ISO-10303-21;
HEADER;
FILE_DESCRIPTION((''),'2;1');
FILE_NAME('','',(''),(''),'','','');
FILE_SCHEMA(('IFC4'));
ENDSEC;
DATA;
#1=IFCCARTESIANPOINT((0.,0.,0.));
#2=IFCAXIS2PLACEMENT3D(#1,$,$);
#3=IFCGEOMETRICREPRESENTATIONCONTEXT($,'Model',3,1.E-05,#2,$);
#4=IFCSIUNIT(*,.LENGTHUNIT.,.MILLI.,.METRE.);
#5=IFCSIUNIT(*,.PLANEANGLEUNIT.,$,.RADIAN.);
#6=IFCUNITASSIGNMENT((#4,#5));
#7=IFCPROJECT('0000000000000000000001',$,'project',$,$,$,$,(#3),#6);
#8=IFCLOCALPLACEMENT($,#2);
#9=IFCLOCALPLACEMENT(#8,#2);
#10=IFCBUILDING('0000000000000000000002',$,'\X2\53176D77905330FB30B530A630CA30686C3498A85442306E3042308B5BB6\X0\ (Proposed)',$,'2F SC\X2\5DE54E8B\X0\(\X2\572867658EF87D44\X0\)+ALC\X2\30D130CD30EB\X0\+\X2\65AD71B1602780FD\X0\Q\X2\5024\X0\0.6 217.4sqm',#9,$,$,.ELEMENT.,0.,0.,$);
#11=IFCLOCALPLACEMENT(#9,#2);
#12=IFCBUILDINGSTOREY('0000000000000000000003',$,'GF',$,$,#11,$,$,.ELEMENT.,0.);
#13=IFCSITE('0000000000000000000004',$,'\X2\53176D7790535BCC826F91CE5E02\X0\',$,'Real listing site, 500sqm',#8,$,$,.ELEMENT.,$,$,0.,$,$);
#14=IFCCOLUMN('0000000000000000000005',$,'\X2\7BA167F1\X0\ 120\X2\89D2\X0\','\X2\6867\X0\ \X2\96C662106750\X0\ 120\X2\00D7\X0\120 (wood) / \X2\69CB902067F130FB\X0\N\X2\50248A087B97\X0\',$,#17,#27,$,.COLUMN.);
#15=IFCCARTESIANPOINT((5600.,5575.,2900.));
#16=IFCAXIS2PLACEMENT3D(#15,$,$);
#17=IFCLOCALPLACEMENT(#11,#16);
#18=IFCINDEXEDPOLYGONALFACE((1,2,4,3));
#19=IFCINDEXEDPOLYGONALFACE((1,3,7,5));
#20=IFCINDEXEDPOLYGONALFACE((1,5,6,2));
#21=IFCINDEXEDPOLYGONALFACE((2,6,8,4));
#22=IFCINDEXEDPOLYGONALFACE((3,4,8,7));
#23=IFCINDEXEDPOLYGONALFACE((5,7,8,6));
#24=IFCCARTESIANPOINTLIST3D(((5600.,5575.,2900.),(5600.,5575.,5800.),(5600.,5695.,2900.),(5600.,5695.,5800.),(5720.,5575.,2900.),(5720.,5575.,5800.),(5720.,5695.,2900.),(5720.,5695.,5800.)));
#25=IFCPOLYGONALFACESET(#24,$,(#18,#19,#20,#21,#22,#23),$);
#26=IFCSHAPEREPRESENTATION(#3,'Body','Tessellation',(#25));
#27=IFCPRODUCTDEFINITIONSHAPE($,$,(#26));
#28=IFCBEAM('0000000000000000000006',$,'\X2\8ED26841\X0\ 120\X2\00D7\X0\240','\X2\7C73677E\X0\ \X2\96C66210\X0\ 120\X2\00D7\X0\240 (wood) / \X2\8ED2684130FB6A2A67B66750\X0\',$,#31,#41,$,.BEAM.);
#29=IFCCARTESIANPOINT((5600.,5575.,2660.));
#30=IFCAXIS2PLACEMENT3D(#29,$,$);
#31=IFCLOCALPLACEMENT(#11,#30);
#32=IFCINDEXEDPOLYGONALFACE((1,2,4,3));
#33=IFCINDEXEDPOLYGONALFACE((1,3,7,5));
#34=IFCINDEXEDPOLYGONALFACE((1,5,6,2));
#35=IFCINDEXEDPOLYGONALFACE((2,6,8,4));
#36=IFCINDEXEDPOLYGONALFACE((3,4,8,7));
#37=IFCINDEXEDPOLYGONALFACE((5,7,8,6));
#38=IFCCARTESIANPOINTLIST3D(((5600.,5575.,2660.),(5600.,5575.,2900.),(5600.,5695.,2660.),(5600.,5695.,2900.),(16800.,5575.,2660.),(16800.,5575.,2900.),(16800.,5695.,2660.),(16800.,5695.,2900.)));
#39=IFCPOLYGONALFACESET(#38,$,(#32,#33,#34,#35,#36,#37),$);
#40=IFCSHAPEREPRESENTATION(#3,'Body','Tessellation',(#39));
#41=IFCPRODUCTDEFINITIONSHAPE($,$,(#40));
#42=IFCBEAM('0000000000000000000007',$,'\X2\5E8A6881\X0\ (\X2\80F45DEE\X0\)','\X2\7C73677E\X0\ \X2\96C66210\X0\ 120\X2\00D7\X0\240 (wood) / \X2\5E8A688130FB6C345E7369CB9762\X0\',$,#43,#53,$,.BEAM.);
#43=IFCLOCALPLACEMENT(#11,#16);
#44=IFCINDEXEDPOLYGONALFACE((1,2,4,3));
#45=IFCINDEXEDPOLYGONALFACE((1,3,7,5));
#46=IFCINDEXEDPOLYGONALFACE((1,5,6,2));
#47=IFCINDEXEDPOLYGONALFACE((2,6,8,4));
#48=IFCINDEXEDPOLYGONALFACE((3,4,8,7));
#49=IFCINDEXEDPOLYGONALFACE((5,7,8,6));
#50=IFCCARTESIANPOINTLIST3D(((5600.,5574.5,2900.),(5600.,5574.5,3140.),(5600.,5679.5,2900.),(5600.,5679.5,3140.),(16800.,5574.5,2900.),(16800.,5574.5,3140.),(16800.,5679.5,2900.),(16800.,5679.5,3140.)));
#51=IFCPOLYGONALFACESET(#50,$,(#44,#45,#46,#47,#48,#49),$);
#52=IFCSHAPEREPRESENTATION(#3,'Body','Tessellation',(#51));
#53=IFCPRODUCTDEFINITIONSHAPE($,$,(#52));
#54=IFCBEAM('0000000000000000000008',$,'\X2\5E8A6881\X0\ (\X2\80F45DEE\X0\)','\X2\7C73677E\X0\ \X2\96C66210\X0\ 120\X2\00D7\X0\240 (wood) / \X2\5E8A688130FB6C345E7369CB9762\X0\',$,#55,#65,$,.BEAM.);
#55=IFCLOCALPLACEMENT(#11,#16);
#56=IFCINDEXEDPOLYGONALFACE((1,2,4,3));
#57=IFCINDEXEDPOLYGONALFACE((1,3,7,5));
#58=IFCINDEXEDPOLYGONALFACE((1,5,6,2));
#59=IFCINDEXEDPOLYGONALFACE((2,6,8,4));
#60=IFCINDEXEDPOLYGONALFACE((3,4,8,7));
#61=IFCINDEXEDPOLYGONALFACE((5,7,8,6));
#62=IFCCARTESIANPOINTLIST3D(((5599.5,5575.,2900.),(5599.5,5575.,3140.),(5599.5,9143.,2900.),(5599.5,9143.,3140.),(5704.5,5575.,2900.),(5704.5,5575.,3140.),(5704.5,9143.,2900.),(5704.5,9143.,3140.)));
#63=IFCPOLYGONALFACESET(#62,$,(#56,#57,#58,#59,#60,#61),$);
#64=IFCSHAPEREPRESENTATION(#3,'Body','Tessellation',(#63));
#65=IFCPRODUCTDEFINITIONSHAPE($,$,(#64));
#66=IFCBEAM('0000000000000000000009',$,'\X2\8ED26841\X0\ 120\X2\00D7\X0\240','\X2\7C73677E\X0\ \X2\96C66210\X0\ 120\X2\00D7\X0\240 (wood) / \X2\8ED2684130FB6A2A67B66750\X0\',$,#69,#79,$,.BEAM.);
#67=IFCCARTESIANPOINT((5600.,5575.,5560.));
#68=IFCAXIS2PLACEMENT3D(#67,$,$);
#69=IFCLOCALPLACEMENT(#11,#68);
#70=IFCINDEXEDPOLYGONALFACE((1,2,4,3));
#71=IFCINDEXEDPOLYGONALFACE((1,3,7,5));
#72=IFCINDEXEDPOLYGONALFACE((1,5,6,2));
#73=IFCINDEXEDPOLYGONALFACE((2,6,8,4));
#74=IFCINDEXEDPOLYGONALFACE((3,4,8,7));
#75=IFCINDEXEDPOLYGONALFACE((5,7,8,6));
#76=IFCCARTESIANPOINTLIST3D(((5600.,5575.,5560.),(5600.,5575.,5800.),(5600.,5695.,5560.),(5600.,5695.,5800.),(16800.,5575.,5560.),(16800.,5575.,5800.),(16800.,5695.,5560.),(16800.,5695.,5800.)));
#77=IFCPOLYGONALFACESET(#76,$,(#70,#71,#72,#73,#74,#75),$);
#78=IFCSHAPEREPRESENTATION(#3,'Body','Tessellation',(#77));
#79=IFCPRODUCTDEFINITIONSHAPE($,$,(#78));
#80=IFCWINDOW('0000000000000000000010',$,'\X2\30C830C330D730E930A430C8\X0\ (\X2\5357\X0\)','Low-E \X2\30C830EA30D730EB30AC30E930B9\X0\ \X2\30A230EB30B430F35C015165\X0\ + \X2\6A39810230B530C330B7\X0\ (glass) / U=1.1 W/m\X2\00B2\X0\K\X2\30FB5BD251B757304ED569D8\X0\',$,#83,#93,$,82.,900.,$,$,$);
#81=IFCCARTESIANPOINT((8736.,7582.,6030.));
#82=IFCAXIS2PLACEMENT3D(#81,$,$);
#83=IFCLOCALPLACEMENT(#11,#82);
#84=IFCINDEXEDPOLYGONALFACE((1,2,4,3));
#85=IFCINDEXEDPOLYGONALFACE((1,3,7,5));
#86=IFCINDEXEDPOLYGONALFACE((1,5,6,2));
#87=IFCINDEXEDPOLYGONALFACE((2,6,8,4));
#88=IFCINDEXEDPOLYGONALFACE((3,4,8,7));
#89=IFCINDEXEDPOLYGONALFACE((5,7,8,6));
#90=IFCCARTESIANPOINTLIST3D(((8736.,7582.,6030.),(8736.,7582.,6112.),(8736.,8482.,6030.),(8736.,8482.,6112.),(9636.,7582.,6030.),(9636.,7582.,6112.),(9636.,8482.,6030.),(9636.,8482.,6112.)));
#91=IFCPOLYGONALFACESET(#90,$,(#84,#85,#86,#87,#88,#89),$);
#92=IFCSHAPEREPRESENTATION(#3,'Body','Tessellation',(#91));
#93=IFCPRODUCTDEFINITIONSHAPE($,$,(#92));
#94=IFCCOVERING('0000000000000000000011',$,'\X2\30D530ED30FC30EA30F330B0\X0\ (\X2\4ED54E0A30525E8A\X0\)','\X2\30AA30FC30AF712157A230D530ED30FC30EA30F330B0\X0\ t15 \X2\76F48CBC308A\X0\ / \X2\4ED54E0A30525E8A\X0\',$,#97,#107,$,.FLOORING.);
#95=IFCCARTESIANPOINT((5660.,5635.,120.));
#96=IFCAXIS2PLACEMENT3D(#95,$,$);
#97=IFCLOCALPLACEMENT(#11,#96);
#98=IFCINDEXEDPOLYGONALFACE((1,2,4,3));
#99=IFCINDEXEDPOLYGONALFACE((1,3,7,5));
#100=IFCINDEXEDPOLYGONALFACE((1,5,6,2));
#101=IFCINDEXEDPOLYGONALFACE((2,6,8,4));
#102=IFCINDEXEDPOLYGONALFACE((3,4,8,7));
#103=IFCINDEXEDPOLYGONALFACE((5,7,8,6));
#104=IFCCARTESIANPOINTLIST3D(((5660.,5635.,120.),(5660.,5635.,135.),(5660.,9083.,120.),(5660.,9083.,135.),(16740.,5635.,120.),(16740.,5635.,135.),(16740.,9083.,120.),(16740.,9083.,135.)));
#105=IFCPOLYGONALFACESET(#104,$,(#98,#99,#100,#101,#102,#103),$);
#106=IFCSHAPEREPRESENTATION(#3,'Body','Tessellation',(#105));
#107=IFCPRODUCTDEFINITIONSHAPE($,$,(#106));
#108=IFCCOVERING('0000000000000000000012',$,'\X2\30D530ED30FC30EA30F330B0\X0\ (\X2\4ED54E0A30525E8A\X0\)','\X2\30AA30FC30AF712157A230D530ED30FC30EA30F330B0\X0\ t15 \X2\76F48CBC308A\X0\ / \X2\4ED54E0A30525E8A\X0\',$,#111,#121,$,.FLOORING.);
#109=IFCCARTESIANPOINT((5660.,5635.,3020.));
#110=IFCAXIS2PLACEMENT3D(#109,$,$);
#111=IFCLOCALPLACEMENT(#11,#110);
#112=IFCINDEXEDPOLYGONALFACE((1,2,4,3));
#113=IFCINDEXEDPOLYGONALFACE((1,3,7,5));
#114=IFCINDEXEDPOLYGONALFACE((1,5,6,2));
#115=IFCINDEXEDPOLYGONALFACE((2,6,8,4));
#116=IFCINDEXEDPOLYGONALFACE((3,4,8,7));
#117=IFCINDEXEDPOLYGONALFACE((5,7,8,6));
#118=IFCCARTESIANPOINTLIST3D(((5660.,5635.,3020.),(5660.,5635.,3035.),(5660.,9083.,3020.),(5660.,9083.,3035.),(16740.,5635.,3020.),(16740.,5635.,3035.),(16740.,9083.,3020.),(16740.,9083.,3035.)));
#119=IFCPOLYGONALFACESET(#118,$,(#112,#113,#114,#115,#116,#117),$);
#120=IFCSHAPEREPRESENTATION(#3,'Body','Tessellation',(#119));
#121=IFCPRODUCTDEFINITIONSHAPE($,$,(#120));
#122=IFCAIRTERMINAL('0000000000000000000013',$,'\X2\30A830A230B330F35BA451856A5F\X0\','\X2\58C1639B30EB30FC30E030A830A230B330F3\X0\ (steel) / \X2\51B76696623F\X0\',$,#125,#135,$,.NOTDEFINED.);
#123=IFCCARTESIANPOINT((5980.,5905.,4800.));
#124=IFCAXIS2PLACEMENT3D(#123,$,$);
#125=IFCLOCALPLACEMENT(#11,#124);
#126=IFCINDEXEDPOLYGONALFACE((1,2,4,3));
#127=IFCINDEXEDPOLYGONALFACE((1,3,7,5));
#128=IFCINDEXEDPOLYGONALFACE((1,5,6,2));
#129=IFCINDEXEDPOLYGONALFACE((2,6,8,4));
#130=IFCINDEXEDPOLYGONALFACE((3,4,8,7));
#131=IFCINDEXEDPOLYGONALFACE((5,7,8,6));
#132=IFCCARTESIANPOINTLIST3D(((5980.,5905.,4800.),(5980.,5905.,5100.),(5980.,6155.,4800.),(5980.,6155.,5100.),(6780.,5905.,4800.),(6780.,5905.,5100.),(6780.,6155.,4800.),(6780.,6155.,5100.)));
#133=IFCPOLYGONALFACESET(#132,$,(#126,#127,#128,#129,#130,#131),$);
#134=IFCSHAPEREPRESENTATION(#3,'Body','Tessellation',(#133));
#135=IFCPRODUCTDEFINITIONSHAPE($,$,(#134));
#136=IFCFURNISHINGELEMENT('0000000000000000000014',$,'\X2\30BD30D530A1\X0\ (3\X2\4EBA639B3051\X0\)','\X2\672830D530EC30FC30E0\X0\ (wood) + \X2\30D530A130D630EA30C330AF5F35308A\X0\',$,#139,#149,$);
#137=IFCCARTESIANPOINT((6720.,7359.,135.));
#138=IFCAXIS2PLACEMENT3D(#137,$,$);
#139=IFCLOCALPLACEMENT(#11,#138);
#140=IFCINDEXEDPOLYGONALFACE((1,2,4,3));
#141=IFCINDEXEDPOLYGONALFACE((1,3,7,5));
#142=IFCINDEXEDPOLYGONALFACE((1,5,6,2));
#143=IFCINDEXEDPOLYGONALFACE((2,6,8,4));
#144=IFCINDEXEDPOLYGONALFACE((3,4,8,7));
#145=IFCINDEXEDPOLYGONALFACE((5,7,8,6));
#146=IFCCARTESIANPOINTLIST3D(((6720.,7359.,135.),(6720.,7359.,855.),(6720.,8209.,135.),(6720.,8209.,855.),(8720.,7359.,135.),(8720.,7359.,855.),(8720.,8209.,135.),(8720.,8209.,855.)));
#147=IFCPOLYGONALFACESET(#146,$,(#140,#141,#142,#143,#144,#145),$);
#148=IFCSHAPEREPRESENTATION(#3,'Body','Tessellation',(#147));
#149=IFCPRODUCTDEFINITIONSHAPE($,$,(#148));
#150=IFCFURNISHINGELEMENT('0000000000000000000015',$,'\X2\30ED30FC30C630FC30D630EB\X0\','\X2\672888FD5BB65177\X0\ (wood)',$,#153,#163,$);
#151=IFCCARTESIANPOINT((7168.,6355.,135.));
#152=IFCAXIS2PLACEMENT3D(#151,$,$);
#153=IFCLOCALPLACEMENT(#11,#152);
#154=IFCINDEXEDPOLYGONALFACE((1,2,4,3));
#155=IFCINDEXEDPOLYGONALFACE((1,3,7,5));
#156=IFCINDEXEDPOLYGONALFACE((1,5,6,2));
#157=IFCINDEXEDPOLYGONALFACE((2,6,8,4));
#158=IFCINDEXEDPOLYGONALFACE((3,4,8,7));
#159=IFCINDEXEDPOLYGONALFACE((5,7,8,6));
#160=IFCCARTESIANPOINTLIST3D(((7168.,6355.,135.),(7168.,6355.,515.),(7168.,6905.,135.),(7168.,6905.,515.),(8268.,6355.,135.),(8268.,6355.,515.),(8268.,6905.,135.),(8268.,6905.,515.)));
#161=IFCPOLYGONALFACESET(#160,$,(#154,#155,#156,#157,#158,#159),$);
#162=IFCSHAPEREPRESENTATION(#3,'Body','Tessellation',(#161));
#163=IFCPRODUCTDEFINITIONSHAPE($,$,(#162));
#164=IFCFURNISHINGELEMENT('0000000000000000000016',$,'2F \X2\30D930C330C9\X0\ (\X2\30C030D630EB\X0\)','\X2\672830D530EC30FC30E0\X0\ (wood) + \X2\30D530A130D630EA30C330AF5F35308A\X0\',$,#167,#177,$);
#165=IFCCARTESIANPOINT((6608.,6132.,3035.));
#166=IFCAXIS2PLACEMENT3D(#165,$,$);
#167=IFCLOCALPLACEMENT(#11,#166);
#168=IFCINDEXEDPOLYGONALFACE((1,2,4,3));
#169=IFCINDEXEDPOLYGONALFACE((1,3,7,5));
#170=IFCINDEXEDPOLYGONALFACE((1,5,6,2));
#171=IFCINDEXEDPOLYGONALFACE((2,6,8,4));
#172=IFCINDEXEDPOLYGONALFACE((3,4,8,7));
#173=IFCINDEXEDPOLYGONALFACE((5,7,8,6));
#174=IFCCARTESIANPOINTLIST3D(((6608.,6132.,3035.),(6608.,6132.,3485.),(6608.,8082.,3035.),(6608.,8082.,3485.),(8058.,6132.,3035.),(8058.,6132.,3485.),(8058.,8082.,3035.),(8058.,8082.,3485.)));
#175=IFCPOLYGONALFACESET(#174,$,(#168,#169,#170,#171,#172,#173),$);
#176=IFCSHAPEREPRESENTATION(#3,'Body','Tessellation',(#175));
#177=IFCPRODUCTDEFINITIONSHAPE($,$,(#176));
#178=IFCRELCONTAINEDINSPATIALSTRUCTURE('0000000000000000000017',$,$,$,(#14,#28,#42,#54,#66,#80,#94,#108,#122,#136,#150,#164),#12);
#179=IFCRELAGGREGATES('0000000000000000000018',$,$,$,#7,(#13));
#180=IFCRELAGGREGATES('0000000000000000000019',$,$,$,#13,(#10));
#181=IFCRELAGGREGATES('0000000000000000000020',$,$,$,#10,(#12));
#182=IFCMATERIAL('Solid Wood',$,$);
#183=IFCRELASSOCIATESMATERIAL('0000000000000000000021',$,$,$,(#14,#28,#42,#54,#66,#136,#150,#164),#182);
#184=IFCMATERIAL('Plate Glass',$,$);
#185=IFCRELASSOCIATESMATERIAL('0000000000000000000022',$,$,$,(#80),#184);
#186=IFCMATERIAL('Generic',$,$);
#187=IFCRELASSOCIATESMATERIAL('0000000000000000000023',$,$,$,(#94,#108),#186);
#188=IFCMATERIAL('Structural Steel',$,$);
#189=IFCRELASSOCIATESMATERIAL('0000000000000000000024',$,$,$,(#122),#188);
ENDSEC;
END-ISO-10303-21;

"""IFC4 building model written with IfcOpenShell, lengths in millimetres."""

from ifc_helpers import new_model, si_unit, frame, frame_2d, origin, place, context, project, spatial, rectangle, extrude, material, element, save


model = new_model("IFC4")

# Units and contexts
model_context = context("Model", 3, precision=1e-05, world=origin())
ifc_project = project(units=[si_unit("LENGTHUNIT", "METRE", prefix="MILLI"), si_unit("PLANEANGLEUNIT", "RADIAN")], contexts=[model_context])

# Site, building, storey
site_placement = place(None, origin())
site = spatial("IfcSite", under=ifc_project, at=site_placement, Name="北海道富良野市", ObjectType="Real listing site, 500sqm", CompositionType="ELEMENT", RefElevation=0.0)
building_placement = place(site_placement, origin())
building = spatial("IfcBuilding", under=site, at=building_placement, Name="北海道・サウナと水風呂のある家 (Proposed)", ObjectType="2F SC工事(在来軸組)+ALCパネル+断熱性能Q値0.6 217.4sqm", CompositionType="ELEMENT", ElevationOfRefHeight=0.0, ElevationOfTerrain=0.0)
storey_placement = place(building_placement, origin())
storey = spatial("IfcBuildingStorey", under=building, at=storey_placement, Name="GF", CompositionType="ELEMENT", Elevation=0.0)

# Column
ifc_material_1 = material(Name="Solid Wood")
column_1_placement = place(storey_placement, frame((5600.0, 5575.0, 2900.0)))
element("IfcColumn", 1, at=column_1_placement, inside=storey, material=ifc_material_1, Name="管柱 120角", Description="桧 集成材 120×120 (wood) / 構造柱・N値計算", PredefinedType="COLUMN", context=model_context, shape_type="SweptSolid", body=[
    extrude(rectangle(XDim=120.0, YDim=120.0, at=frame_2d((60.0, 60.0))), frame((5600.0, 5575.0, 2900.0)), (0.0, 0.0, 1.0), 2900.0),
])

# Beams
beam_1_placement = place(storey_placement, frame((5600.0, 5575.0, 2660.0)))
element("IfcBeam", 2, at=beam_1_placement, inside=storey, material=ifc_material_1, Name="軒桁 120×240", Description="米松 集成 120×240 (wood) / 軒桁・横架材", PredefinedType="BEAM", context=model_context, shape_type="SweptSolid", body=[
    extrude(rectangle(XDim=11200.0, YDim=120.0, at=frame_2d((5600.0, 60.0))), frame((5600.0, 5575.0, 2660.0)), (0.0, 0.0, 1.0), 240.0),
])
beam_2_placement = place(storey_placement, frame((5600.0, 5575.0, 2900.0)))
element("IfcBeam", 3, at=beam_2_placement, inside=storey, material=ifc_material_1, Name="床梁 (胴差)", Description="米松 集成 120×240 (wood) / 床梁・水平構面", PredefinedType="BEAM", context=model_context, shape_type="SweptSolid", body=[
    extrude(rectangle(XDim=11200.0, YDim=105.0, at=frame_2d((5600.0, 52.0))), frame((5600.0, 5575.0, 2900.0)), (0.0, 0.0, 1.0), 240.0),
])
beam_3_placement = place(storey_placement, frame((5600.0, 5575.0, 2900.0)))
element("IfcBeam", 4, at=beam_3_placement, inside=storey, material=ifc_material_1, Name="床梁 (胴差)", Description="米松 集成 120×240 (wood) / 床梁・水平構面", PredefinedType="BEAM", context=model_context, shape_type="SweptSolid", body=[
    extrude(rectangle(XDim=105.0, YDim=3568.0, at=frame_2d((52.0, 1784.0))), frame((5600.0, 5575.0, 2900.0)), (0.0, 0.0, 1.0), 240.0),
])
beam_4_placement = place(storey_placement, frame((5600.0, 5575.0, 5560.0)))
element("IfcBeam", 5, at=beam_4_placement, inside=storey, material=ifc_material_1, Name="軒桁 120×240", Description="米松 集成 120×240 (wood) / 軒桁・横架材", PredefinedType="BEAM", context=model_context, shape_type="SweptSolid", body=[
    extrude(rectangle(XDim=11200.0, YDim=120.0, at=frame_2d((5600.0, 60.0))), frame((5600.0, 5575.0, 5560.0)), (0.0, 0.0, 1.0), 240.0),
])

# Window
ifc_material_2 = material(Name="Plate Glass")
window_placement = place(storey_placement, frame((8736.0, 7582.0, 6030.0)))
element("IfcWindow", 6, at=window_placement, inside=storey, material=ifc_material_2, Name="トップライト (南)", Description="Low-E トリプルガラス アルゴン封入 + 樹脂サッシ (glass) / U=1.1 W/m²K・寒冷地仕様", OverallHeight=82.0, OverallWidth=900.0, context=model_context, shape_type="SweptSolid", body=[
    extrude(rectangle(XDim=900.0, YDim=900.0, at=frame_2d((450.0, 450.0))), frame((8736.0, 7582.0, 6030.0)), (0.0, 0.0, 1.0), 82.0),
])

# Coverings
ifc_material_3 = material(Name="Generic")
covering_1_placement = place(storey_placement, frame((5660.0, 5635.0, 120.0)))
element("IfcCovering", 7, at=covering_1_placement, inside=storey, material=ifc_material_3, Name="フローリング (仕上げ床)", Description="オーク無垢フローリング t15 直貼り / 仕上げ床", PredefinedType="FLOORING", context=model_context, shape_type="SweptSolid", body=[
    extrude(rectangle(XDim=11080.0, YDim=3448.0, at=frame_2d((5540.0, 1724.0))), frame((5660.0, 5635.0, 120.0)), (0.0, 0.0, 1.0), 15.0),
])
covering_2_placement = place(storey_placement, frame((5660.0, 5635.0, 3020.0)))
element("IfcCovering", 8, at=covering_2_placement, inside=storey, material=ifc_material_3, Name="フローリング (仕上げ床)", Description="オーク無垢フローリング t15 直貼り / 仕上げ床", PredefinedType="FLOORING", context=model_context, shape_type="SweptSolid", body=[
    extrude(rectangle(XDim=11080.0, YDim=3448.0, at=frame_2d((5540.0, 1724.0))), frame((5660.0, 5635.0, 3020.0)), (0.0, 0.0, 1.0), 15.0),
])

# Air terminal
ifc_material_4 = material(Name="Structural Steel")
air_terminal_placement = place(storey_placement, frame((5980.0, 5905.0, 4800.0)))
element("IfcAirTerminal", 9, at=air_terminal_placement, inside=storey, material=ifc_material_4, Name="エアコン室内機", Description="壁掛ルームエアコン (steel) / 冷暖房", PredefinedType="NOTDEFINED", context=model_context, shape_type="SweptSolid", body=[
    extrude(rectangle(XDim=800.0, YDim=250.0, at=frame_2d((400.0, 125.0))), frame((5980.0, 5905.0, 4800.0)), (0.0, 0.0, 1.0), 300.0),
])

# Furnishing elements
furnishing_1_placement = place(storey_placement, frame((6720.0, 7359.0, 135.0)))
element("IfcFurnishingElement", 10, at=furnishing_1_placement, inside=storey, material=ifc_material_1, Name="ソファ (3人掛け)", Description="木フレーム (wood) + ファブリック張り", context=model_context, shape_type="SweptSolid", body=[
    extrude(rectangle(XDim=2000.0, YDim=850.0, at=frame_2d((1000.0, 425.0))), frame((6720.0, 7359.0, 135.0)), (0.0, 0.0, 1.0), 720.0),
])
furnishing_2_placement = place(storey_placement, frame((7168.0, 6355.0, 135.0)))
element("IfcFurnishingElement", 11, at=furnishing_2_placement, inside=storey, material=ifc_material_1, Name="ローテーブル", Description="木製家具 (wood)", context=model_context, shape_type="SweptSolid", body=[
    extrude(rectangle(XDim=1100.0, YDim=550.0, at=frame_2d((550.0, 275.0))), frame((7168.0, 6355.0, 135.0)), (0.0, 0.0, 1.0), 380.0),
])
furnishing_3_placement = place(storey_placement, frame((6608.0, 6132.0, 3035.0)))
element("IfcFurnishingElement", 12, at=furnishing_3_placement, inside=storey, material=ifc_material_1, Name="2F ベッド (ダブル)", Description="木フレーム (wood) + ファブリック張り", context=model_context, shape_type="SweptSolid", body=[
    extrude(rectangle(XDim=1450.0, YDim=1950.0, at=frame_2d((725.0, 975.0))), frame((6608.0, 6132.0, 3035.0)), (0.0, 0.0, 1.0), 450.0),
])

save(model, "model.ifc")
